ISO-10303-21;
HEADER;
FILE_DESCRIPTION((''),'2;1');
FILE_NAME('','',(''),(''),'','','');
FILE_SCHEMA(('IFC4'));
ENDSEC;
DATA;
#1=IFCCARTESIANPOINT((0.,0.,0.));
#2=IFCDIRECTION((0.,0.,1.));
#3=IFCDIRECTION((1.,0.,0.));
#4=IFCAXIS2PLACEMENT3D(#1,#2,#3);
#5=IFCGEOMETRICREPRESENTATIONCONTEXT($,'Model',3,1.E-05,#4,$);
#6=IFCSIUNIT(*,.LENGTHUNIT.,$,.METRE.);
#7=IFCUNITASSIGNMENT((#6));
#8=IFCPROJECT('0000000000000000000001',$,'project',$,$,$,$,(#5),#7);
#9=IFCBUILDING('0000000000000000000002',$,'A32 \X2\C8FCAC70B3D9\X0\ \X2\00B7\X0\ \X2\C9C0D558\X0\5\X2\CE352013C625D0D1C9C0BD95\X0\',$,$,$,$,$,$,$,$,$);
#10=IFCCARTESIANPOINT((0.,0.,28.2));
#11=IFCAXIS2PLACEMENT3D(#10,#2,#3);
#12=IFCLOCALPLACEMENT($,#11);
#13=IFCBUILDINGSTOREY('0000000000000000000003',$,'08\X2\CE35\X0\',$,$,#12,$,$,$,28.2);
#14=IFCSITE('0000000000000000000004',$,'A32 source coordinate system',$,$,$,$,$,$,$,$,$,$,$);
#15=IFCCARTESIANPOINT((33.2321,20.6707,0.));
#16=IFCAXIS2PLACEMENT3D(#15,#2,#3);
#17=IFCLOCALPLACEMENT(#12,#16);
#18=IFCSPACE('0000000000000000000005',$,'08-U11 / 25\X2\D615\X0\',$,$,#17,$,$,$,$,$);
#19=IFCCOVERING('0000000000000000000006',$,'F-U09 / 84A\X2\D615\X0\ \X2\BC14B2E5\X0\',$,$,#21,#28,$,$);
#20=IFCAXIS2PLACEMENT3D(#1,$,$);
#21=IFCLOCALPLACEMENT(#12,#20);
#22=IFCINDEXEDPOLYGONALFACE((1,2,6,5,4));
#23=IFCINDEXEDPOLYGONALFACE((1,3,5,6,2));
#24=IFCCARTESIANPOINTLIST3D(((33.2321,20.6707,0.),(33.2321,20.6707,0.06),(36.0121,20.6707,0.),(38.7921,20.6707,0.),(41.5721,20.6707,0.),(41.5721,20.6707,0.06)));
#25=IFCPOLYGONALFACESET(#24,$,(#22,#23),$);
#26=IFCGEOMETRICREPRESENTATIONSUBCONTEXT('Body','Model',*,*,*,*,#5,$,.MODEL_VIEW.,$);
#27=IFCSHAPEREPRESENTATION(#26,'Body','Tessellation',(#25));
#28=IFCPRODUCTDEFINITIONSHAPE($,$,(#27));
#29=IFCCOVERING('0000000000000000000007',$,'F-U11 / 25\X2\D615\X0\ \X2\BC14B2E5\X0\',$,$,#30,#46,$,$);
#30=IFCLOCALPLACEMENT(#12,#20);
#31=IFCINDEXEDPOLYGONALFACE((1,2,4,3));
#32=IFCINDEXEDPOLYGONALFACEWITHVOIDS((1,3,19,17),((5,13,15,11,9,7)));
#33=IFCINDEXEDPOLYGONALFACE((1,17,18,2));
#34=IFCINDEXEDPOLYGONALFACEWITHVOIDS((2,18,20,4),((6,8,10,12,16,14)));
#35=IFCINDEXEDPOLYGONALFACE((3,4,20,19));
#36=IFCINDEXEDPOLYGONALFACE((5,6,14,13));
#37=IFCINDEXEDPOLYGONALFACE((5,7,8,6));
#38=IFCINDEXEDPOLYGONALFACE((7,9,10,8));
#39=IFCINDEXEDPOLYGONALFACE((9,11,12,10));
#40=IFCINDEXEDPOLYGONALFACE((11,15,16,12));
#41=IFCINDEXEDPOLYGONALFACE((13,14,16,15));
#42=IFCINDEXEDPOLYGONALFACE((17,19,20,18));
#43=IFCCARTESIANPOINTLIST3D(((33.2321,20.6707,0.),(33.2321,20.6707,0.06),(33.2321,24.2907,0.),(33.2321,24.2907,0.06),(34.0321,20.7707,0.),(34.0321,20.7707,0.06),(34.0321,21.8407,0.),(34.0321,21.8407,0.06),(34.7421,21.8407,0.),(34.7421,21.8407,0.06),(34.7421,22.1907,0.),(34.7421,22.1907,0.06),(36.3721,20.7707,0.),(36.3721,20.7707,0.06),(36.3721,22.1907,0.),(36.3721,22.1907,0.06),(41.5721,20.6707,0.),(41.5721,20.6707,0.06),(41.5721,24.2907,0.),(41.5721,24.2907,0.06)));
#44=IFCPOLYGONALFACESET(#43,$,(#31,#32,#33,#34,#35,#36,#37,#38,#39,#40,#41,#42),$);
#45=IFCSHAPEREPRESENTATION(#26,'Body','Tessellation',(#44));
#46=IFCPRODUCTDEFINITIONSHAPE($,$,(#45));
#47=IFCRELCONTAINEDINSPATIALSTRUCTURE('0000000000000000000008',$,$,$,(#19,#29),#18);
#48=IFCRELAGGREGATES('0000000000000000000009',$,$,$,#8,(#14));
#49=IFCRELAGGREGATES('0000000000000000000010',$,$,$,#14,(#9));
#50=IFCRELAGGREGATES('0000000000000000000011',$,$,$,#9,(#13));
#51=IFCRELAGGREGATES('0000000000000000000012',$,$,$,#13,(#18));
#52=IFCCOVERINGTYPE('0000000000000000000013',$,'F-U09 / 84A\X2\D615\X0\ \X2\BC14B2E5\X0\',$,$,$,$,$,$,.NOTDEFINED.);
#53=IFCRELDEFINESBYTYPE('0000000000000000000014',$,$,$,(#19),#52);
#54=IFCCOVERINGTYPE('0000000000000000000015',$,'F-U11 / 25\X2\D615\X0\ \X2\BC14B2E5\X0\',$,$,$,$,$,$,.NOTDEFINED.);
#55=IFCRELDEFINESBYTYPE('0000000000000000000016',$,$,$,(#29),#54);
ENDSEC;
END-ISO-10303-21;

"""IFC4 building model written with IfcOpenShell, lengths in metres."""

from ifc_helpers import new_model, si_unit, frame, origin, origin_with_axes, place, context, subcontext, project, spatial, polyline, outline, extrude, source, transform, mapped, type_object, type_shapes, element, save


model = new_model("IFC4")

# Units and contexts
model_context = context("Model", 3, precision=1e-05, world=origin_with_axes())
body_context = subcontext(model_context, "Body", "Model", "MODEL_VIEW")
ifc_project = project(units=[si_unit("LENGTHUNIT", "METRE")], contexts=[model_context])

# Site, building, storey
site = spatial("IfcSite", under=ifc_project, Name="A32 source coordinate system")
building = spatial("IfcBuilding", under=site, Name="A32 주거동 · 지하5층–옥탑지붕")
storey_placement = place(None, frame((0.0, 0.0, 28.2), z_axis=(0.0, 0.0, 1.0), x_axis=(1.0, 0.0, 0.0)))
storey = spatial("IfcBuildingStorey", under=building, at=storey_placement, Name="08층", Elevation=28.2)

# Shared definitions
space_1_placement = place(storey_placement, frame((33.2321, 20.6707, 0.0), z_axis=(0.0, 0.0, 1.0), x_axis=(1.0, 0.0, 0.0)))
space_1 = spatial("IfcSpace", under=storey, at=space_1_placement, Name="08-U11 / 25형")

# Coverings
covering_type_1 = type_object("IfcCoveringType", Name="F-U09 / 84A형 바닥", PredefinedType="NOTDEFINED")
shared_shape_1 = source(origin(), body_context, "Body", "SweptSolid", [
    extrude(outline(polyline([(0.0, 0.0), (8.34, 0.0), (8.34, 0.0), (0.0, 0.0), (0.0, 0.0)])), origin(), (0.0, 0.0, 1.0), 0.06),
])
type_shapes(covering_type_1, [shared_shape_1])
covering_1_placement = place(space_1_placement, origin_with_axes())
element("IfcCovering", 1, at=covering_1_placement, inside=space_1, type_object=covering_type_1, Name="F-U09 / 84A형 바닥", context=body_context, shape_type="MappedRepresentation", body=[
    mapped(shared_shape_1, transform((0.0, 0.0, 0.0), scale=1.0)),
])
covering_type_2 = type_object("IfcCoveringType", Name="F-U11 / 25형 바닥", PredefinedType="NOTDEFINED")
shared_shape_2 = source(origin(), body_context, "Body", "SweptSolid", [
    extrude(outline(polyline([(0.0, 0.0), (0.0, 3.62), (8.34, 3.62), (8.34, 0.0), (0.0, 0.0)]), holes=[polyline([(1.51, 1.17), (0.8, 1.17), (0.8, 0.1), (3.14, 0.1), (3.14, 1.52), (1.51, 1.52), (1.51, 1.17)])]), origin(), (0.0, 0.0, 1.0), 0.06),
])
type_shapes(covering_type_2, [shared_shape_2])
covering_2_placement = place(space_1_placement, origin_with_axes())
element("IfcCovering", 2, at=covering_2_placement, inside=space_1, type_object=covering_type_2, Name="F-U11 / 25형 바닥", context=body_context, shape_type="MappedRepresentation", body=[
    mapped(shared_shape_2, transform((0.0, 0.0, 0.0), scale=1.0)),
])

save(model, "model.ifc")
